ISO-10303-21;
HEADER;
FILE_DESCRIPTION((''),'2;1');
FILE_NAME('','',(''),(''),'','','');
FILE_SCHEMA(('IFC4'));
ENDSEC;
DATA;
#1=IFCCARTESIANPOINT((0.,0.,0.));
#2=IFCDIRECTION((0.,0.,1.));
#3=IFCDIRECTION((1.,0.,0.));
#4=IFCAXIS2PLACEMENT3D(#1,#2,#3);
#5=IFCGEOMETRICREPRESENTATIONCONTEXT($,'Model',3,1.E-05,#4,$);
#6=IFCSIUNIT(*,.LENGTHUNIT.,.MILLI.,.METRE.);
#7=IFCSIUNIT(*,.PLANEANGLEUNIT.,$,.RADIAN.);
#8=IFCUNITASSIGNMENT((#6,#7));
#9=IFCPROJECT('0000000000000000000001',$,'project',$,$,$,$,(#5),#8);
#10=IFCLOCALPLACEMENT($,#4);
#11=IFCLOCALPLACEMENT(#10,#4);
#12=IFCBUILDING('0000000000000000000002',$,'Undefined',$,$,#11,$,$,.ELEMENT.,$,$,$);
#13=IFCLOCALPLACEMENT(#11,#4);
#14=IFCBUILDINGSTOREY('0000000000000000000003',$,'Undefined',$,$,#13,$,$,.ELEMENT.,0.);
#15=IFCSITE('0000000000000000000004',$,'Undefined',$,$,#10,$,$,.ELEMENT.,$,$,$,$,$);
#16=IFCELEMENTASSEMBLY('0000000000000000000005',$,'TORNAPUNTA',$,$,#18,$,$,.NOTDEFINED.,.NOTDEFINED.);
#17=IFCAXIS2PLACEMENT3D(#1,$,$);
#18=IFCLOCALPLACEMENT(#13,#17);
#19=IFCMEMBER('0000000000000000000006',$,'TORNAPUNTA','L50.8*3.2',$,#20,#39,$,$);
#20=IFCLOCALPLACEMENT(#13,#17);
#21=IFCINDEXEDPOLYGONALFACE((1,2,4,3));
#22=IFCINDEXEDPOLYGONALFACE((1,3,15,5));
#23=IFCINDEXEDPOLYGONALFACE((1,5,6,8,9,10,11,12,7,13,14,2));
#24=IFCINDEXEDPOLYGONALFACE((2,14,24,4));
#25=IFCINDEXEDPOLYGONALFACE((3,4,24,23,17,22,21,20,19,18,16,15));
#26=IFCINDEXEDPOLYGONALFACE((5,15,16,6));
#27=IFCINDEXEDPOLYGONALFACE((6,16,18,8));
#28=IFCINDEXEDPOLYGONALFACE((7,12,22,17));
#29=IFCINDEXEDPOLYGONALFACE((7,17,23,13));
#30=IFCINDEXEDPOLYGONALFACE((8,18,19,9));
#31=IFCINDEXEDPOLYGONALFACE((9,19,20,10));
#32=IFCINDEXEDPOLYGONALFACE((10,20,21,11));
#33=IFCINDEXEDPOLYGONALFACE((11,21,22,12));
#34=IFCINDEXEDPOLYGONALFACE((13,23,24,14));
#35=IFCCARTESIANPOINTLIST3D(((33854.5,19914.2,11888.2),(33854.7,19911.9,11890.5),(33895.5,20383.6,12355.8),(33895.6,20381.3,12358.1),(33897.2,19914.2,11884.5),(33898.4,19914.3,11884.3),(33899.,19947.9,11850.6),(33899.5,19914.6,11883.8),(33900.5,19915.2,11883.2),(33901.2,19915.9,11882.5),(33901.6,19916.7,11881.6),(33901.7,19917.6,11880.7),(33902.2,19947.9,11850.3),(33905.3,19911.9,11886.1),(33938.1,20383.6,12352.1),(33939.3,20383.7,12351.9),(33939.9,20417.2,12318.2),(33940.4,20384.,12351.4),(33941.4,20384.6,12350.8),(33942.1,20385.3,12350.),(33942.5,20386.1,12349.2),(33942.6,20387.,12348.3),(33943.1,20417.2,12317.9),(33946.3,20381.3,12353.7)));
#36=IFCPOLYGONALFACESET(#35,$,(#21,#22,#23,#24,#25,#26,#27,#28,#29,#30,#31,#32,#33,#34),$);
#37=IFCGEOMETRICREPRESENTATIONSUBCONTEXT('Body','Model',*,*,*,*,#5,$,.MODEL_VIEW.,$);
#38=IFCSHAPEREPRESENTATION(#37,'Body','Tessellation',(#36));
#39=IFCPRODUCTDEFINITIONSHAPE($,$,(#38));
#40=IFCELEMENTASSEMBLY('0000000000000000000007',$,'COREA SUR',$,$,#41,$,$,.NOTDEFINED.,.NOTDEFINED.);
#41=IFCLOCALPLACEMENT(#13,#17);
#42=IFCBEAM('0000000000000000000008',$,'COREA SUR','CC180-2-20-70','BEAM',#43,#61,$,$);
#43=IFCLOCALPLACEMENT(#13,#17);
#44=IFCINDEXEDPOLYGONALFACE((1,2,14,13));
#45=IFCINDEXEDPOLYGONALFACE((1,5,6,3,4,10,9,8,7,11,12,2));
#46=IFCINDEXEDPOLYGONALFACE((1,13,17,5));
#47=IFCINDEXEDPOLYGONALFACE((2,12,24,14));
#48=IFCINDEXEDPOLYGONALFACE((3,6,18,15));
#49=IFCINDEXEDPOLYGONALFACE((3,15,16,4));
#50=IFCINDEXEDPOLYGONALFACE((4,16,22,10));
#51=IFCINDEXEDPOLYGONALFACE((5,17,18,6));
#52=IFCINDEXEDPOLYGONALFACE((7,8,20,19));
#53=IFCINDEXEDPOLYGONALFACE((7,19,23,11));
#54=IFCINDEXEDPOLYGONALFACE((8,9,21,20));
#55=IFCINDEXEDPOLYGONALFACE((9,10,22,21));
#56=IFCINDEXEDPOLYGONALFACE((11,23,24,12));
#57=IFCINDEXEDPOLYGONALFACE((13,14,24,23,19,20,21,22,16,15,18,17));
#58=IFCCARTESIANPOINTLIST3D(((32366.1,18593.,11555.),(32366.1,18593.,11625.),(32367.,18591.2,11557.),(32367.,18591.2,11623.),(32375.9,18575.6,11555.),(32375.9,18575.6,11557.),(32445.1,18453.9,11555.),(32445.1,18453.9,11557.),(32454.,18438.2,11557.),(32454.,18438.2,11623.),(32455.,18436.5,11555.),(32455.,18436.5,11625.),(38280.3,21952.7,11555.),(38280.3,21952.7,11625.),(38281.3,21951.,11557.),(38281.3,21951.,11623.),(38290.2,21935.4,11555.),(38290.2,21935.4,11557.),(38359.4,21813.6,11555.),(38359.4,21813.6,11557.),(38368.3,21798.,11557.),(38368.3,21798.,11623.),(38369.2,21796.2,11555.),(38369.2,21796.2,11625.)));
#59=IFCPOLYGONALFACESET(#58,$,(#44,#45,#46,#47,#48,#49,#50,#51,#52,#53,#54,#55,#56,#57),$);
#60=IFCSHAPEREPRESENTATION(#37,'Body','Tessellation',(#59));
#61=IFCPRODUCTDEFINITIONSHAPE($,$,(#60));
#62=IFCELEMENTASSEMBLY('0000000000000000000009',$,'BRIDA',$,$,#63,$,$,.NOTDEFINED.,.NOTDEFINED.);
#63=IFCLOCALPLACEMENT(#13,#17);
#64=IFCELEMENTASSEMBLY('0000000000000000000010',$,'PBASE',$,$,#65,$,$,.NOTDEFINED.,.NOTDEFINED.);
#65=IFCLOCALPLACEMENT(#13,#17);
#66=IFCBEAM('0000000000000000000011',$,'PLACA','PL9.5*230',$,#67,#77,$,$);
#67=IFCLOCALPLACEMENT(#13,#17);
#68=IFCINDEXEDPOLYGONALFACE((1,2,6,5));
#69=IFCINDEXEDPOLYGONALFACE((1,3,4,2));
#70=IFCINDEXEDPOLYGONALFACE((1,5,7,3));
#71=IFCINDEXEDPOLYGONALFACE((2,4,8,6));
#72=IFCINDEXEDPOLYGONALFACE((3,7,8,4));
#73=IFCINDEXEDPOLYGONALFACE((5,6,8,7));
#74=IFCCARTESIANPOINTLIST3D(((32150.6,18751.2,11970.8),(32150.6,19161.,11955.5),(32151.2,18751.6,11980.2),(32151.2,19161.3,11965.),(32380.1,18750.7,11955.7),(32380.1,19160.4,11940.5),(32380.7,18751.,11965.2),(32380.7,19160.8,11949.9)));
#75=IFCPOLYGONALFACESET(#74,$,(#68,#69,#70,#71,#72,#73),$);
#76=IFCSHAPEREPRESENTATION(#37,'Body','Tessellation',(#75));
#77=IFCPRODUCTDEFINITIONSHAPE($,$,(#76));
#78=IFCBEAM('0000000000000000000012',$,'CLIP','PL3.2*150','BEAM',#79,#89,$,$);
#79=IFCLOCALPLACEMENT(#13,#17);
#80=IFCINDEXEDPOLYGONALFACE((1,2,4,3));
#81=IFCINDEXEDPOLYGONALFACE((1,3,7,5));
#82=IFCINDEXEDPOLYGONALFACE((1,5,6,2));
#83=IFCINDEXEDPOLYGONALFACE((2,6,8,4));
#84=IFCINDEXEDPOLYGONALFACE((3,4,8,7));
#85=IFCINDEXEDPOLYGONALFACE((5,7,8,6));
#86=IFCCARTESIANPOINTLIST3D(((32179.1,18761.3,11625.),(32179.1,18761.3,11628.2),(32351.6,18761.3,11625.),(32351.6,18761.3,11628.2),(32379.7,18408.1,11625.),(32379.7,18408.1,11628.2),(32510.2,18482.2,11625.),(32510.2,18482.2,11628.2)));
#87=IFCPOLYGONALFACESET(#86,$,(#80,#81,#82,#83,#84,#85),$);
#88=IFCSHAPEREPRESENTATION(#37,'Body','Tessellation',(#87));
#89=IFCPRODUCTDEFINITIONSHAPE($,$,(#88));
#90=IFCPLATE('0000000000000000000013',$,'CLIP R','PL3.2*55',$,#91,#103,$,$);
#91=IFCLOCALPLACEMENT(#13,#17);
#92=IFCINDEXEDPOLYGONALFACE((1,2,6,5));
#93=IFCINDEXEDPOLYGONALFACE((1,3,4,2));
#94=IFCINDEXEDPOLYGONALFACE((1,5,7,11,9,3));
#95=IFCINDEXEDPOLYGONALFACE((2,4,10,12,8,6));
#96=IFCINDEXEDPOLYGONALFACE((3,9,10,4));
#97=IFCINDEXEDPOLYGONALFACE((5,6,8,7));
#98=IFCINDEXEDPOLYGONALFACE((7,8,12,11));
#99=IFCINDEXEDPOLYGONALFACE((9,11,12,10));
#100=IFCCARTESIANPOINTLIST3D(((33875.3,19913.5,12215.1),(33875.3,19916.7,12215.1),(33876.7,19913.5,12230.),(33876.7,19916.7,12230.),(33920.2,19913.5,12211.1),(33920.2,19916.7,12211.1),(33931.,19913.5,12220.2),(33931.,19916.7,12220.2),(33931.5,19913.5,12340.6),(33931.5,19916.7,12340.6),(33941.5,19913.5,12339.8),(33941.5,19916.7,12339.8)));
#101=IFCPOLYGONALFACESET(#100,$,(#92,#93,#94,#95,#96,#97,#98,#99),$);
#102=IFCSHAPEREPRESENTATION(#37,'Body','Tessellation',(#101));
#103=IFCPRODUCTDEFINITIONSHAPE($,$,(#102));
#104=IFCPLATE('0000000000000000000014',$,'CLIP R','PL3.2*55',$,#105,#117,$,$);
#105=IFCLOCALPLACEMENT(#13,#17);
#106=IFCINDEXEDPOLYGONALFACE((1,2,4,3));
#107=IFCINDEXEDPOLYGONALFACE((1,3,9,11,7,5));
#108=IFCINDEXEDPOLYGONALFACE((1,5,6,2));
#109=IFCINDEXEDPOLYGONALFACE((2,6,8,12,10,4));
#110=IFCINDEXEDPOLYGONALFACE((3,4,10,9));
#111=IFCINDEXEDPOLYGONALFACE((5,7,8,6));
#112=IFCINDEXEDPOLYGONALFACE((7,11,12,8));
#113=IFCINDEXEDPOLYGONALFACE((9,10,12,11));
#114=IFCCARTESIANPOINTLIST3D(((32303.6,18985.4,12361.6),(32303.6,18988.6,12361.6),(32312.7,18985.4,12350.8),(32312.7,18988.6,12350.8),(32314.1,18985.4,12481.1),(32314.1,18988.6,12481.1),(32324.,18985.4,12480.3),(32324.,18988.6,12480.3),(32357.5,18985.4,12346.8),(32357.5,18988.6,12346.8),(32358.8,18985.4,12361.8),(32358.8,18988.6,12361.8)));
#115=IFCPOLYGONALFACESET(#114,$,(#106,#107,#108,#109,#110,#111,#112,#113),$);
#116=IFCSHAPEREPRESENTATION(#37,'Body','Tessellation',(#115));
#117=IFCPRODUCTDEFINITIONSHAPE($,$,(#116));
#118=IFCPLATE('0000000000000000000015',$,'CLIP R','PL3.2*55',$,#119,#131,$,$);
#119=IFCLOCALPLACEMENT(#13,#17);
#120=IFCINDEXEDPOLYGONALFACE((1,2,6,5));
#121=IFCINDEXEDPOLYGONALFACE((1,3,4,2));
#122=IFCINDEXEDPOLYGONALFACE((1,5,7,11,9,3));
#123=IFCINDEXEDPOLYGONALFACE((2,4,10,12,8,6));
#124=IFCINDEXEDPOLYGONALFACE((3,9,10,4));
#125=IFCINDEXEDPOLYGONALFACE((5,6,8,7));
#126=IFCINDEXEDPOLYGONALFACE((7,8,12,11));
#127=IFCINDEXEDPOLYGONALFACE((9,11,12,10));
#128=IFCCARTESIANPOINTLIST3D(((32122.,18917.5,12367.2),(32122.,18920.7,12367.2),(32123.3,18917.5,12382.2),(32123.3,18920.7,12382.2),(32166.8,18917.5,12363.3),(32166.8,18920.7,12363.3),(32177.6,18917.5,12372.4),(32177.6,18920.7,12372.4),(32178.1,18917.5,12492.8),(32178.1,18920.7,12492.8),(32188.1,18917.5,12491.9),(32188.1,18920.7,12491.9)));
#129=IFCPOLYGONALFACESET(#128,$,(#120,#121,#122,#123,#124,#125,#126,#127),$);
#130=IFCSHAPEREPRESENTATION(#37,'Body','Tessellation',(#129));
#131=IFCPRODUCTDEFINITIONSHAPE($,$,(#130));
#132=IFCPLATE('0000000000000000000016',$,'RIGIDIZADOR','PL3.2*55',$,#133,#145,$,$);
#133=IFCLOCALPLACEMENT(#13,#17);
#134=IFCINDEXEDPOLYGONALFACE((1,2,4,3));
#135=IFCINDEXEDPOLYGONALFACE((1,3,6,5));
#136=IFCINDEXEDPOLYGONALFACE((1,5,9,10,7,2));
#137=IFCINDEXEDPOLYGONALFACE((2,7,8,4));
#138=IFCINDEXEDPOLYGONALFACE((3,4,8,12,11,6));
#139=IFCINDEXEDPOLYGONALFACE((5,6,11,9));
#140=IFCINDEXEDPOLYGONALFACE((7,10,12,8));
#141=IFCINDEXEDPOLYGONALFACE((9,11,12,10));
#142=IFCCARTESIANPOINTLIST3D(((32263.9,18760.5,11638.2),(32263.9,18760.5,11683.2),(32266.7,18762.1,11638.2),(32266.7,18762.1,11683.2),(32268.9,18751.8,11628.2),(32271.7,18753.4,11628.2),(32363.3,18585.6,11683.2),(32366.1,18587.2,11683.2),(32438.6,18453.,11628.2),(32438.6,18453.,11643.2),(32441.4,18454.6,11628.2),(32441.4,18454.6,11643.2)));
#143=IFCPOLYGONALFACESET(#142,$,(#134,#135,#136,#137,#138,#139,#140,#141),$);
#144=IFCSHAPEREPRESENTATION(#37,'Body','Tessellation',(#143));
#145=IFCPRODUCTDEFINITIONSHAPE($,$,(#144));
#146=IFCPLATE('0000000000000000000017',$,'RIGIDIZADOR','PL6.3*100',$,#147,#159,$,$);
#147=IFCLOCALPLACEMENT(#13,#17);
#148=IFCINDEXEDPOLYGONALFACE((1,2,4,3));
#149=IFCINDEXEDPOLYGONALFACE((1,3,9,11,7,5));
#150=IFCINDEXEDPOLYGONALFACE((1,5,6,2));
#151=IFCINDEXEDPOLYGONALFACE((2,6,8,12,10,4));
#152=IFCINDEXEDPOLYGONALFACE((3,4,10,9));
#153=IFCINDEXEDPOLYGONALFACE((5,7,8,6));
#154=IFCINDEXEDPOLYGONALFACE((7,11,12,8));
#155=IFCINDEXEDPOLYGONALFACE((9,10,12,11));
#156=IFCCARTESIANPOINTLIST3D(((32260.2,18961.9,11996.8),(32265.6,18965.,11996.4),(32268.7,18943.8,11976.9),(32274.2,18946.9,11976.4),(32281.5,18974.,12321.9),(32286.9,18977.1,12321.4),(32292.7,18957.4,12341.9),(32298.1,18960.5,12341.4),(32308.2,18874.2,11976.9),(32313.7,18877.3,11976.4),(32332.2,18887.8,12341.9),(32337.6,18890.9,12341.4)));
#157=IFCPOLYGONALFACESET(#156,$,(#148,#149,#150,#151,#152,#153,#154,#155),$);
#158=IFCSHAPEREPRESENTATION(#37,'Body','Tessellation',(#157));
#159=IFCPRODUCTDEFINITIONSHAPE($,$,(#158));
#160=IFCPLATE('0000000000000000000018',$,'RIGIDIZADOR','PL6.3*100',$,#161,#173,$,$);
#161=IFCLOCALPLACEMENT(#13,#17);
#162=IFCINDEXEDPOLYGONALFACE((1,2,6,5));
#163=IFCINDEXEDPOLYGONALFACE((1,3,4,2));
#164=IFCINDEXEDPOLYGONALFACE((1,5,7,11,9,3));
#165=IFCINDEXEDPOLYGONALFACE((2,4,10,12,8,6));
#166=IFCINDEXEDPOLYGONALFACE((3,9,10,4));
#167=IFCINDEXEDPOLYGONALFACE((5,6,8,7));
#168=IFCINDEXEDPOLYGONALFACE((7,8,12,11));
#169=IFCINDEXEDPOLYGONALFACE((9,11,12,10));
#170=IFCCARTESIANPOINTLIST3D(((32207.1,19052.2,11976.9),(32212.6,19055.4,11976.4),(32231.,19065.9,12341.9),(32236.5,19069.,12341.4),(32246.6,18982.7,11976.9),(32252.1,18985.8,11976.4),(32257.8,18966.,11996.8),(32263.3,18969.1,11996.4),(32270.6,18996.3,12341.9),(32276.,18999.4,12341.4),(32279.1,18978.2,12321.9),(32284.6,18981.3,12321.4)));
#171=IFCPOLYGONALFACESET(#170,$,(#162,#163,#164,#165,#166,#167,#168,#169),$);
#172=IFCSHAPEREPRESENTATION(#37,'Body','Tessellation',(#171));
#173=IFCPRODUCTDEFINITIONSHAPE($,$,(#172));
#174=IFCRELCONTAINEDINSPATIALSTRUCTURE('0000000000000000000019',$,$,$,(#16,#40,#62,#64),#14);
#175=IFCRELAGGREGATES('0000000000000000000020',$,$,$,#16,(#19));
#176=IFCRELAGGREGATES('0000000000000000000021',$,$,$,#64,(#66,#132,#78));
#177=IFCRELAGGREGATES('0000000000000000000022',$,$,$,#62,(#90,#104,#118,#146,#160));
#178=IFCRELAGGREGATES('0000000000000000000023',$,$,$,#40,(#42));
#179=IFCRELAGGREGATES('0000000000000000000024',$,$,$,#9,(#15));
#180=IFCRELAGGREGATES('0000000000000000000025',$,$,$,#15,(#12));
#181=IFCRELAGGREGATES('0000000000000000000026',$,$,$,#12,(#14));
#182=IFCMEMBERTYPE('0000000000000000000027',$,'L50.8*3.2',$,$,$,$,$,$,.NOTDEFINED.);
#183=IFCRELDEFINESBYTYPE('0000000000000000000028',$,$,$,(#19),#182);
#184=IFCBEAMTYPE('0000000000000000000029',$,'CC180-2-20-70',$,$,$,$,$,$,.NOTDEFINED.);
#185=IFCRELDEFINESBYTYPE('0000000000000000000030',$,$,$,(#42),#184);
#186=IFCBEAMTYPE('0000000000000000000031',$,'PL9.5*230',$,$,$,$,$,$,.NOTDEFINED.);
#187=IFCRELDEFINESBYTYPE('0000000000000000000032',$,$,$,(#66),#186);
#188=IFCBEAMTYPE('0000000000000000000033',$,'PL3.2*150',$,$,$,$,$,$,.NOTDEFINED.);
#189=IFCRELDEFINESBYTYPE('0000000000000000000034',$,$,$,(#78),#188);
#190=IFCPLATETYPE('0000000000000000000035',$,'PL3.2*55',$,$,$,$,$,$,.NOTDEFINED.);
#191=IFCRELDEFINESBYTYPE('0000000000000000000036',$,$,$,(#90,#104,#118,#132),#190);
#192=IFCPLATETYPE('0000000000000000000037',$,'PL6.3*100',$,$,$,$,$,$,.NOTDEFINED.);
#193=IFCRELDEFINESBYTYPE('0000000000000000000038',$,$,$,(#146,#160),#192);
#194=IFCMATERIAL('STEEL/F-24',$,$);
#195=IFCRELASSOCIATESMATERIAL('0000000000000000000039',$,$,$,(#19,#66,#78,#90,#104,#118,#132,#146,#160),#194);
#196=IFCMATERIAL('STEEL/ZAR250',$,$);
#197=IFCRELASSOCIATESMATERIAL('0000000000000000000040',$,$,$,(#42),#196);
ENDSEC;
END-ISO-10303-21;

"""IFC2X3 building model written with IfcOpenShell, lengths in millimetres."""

from ifc_helpers import new_model, si_unit, frame, origin_with_axes, origin_2d_with_axis, place, context, subcontext, project, spatial, polyline, rectangle, l_section, c_section, outline, extrude, clip, halfspace, material, type_object, element, aggregate, save


model = new_model("IFC2X3")

# Units and contexts
model_context = context("Model", 3, precision=1e-05, world=origin_with_axes())
body_context = subcontext(model_context, "Body", "Model", "MODEL_VIEW")
ifc_project = project(units=[si_unit("LENGTHUNIT", "METRE", prefix="MILLI"), si_unit("PLANEANGLEUNIT", "RADIAN")], contexts=[model_context])

# Site, building, storey
site_placement = place(None, origin_with_axes())
site = spatial("IfcSite", under=ifc_project, at=site_placement, Name="Undefined", CompositionType="ELEMENT")
building_placement = place(site_placement, origin_with_axes())
building = spatial("IfcBuilding", under=site, at=building_placement, Name="Undefined", CompositionType="ELEMENT")
storey_placement = place(building_placement, origin_with_axes())
storey = spatial("IfcBuildingStorey", under=building, at=storey_placement, Name="Undefined", CompositionType="ELEMENT", Elevation=0.0)

# Element assembly, member
assembly_1_placement = place(storey_placement, origin_with_axes())
assembly_1 = element("IfcElementAssembly", 1, at=assembly_1_placement, inside=storey, Name="TORNAPUNTA", AssemblyPlace="NOTDEFINED", PredefinedType="NOTDEFINED")
ifc_material_1 = material(Name="STEEL/F-24")
member_type_1 = type_object("IfcMemberType", Name="L50.8*3.2", PredefinedType="NOTDEFINED")
member_1_placement = place(assembly_1_placement, frame((33878.5, 19929.9, 11870.4), z_axis=(-0.061634, 0.707107, -0.704416), x_axis=(0.061634, 0.707107, 0.704416)))
member_1 = element("IfcMember", 2, at=member_1_placement, type_object=member_type_1, material=ifc_material_1, Name="TORNAPUNTA", Description="L50.8*3.2", context=body_context, shape_type="SweptSolid", body=[
    extrude(l_section(Depth=50.8, Width=50.8, Thickness=3.2, FilletRadius=4.8, at=origin_2d_with_axis()), frame((663.8, 0.0, 0.0), z_axis=(-1.0, 0.0, 0.0), x_axis=(0.0, -1.0, 0.0)), (0.0, 0.0, 1.0), 663.8),
])
aggregate(assembly_1, [member_1])

# Element assembly, beam
assembly_2_placement = place(storey_placement, origin_with_axes())
assembly_2 = element("IfcElementAssembly", 3, at=assembly_2_placement, inside=storey, Name="COREA SUR", AssemblyPlace="NOTDEFINED", PredefinedType="NOTDEFINED")
ifc_material_2 = material(Name="STEEL/ZAR250")
beam_type_1 = type_object("IfcBeamType", Name="CC180-2-20-70", PredefinedType="NOTDEFINED")
beam_1_placement = place(assembly_2_placement, frame((32410.5, 18514.7, 11590.0), z_axis=(0.493942, -0.869495, 0.0), x_axis=(0.869495, 0.493942, 0.0)))
beam_1 = element("IfcBeam", 4, at=beam_1_placement, type_object=beam_type_1, material=ifc_material_2, Name="COREA SUR", Description="CC180-2-20-70", ObjectType="BEAM", context=body_context, shape_type="SweptSolid", body=[
    extrude(c_section(Depth=180.0, Width=70.0, WallThickness=2.0, Girth=20.0, at=origin_2d_with_axis()), frame((6802.0, 0.0, 0.0), z_axis=(-1.0, 0.0, 0.0), x_axis=(0.0, -1.0, 0.0)), (0.0, 0.0, 1.0), 6802.0),
])

# Element assembly
assembly_3_placement = place(storey_placement, origin_with_axes())
assembly_3 = element("IfcElementAssembly", 5, at=assembly_3_placement, inside=storey, Name="BRIDA", AssemblyPlace="NOTDEFINED", PredefinedType="NOTDEFINED")

# Element assembly, beams
assembly_4_placement = place(storey_placement, origin_with_axes())
assembly_4 = element("IfcElementAssembly", 6, at=assembly_4_placement, inside=storey, Name="PBASE", AssemblyPlace="NOTDEFINED", PredefinedType="NOTDEFINED")
beam_type_2 = type_object("IfcBeamType", Name="PL9.5*230", PredefinedType="NOTDEFINED")
beam_2_placement = place(assembly_4_placement, frame((32265.6, 18751.1, 11968.0), z_axis=(0.997859, -0.002436, -0.065364), x_axis=(0.0, 0.999306, -0.037243)))
beam_2 = element("IfcBeam", 7, at=beam_2_placement, type_object=beam_type_2, material=ifc_material_1, Name="PLACA", Description="PL9.5*230", context=body_context, shape_type="SweptSolid", body=[
    extrude(rectangle(XDim=9.5, YDim=230.0, at=origin_2d_with_axis()), frame((410.0, 0.0, 0.0), z_axis=(-1.0, 0.0, 0.0), x_axis=(0.0, -1.0, 0.0)), (0.0, 0.0, 1.0), 410.0),
])
beam_type_3 = type_object("IfcBeamType", Name="PL3.2*150", PredefinedType="NOTDEFINED")
beam_3_placement = place(assembly_4_placement, frame((32265.3, 18761.3, 11626.6), z_axis=(0.869505, 0.493924, 0.0), x_axis=(0.493924, -0.869505, 0.0)))
beam_3 = element("IfcBeam", 8, at=beam_3_placement, type_object=beam_type_3, material=ifc_material_1, Name="CLIP", Description="PL3.2*150", ObjectType="BEAM", context=body_context, shape_type="Clipping", body=[
    clip(extrude(rectangle(XDim=3.2, YDim=150.0, at=origin_2d_with_axis()), frame((363.7, 0.0, 0.0), z_axis=(-1.0, 0.0, 0.0), x_axis=(0.0, -1.0, 0.0)), (0.0, 0.0, 1.0), 471.8), halfspace(frame((0.0, 0.0, 0.0), z_axis=(0.869505, 0.0, -0.493924), x_axis=(-0.493924, 0.0, -0.869505)), True)),
])

# Plates
plate_type_1 = type_object("IfcPlateType", Name="PL3.2*55", PredefinedType="NOTDEFINED")
plate_1_placement = place(assembly_3_placement, frame((33941.5, 19915.1, 12339.8), z_axis=(0.0, -1.0, 0.0), x_axis=(-0.996194, 0.0, 0.087163)))
plate_1 = element("IfcPlate", 9, at=plate_1_placement, type_object=plate_type_1, material=ifc_material_1, Name="CLIP R", Description="PL3.2*55", context=body_context, shape_type="SweptSolid", body=[
    extrude(outline(polyline([(0.0, 0.0), (10.0, 0.0), (55.0, 115.0), (55.0, 130.0), (10.0, 130.0), (0.0, 120.0), (0.0, 0.0)])), frame((0.0, 0.0, -1.6), z_axis=(0.0, 0.0, 1.0), x_axis=(1.0, 0.0, 0.0)), (0.0, 0.0, 1.0), 3.2),
])
plate_2_placement = place(assembly_3_placement, frame((32314.1, 18987.0, 12481.1), z_axis=(0.0, 1.0, 0.0), x_axis=(0.996195, 0.0, -0.087155)))
plate_2 = element("IfcPlate", 10, at=plate_2_placement, type_object=plate_type_1, material=ifc_material_1, Name="CLIP R", Description="PL3.2*55", context=body_context, shape_type="SweptSolid", body=[
    extrude(outline(polyline([(0.0, 0.0), (10.0, 0.0), (55.0, 115.0), (55.0, 130.0), (10.0, 130.0), (0.0, 120.0), (0.0, 0.0)])), frame((0.0, 0.0, -1.6), z_axis=(0.0, 0.0, 1.0), x_axis=(1.0, 0.0, 0.0)), (0.0, 0.0, 1.0), 3.2),
])
plate_3_placement = place(assembly_3_placement, frame((32188.1, 18919.1, 12491.9), z_axis=(0.0, -1.0, 0.0), x_axis=(-0.996194, 0.0, 0.087163)))
plate_3 = element("IfcPlate", 11, at=plate_3_placement, type_object=plate_type_1, material=ifc_material_1, Name="CLIP R", Description="PL3.2*55", context=body_context, shape_type="SweptSolid", body=[
    extrude(outline(polyline([(0.0, 0.0), (10.0, 0.0), (55.0, 115.0), (55.0, 130.0), (10.0, 130.0), (0.0, 120.0), (0.0, 0.0)])), frame((0.0, 0.0, -1.6), z_axis=(0.0, 0.0, 1.0), x_axis=(1.0, 0.0, 0.0)), (0.0, 0.0, 1.0), 3.2),
])
plate_4_placement = place(assembly_4_placement, frame((32364.7, 18586.4, 11683.2), z_axis=(0.869505, 0.493924, 0.0), x_axis=(0.477762, -0.841054, -0.253717)))
plate_4 = element("IfcPlate", 12, at=plate_4_placement, type_object=plate_type_1, material=ifc_material_1, Name="RIGIDIZADOR", Description="PL3.2*55", context=body_context, shape_type="SweptSolid", body=[
    extrude(outline(polyline([(0.0, 0.0), (157.7, 0.0), (161.5, 14.5), (-171.0, 101.7), (-183.2, 94.6), (-194.6, 51.0), (0.0, 0.0)])), frame((0.0, 0.0, -1.6), z_axis=(0.0, 0.0, 1.0), x_axis=(1.0, 0.0, 0.0)), (0.0, 0.0, 1.0), 3.2),
])
aggregate(assembly_4, [beam_2, plate_4, beam_3])
plate_type_2 = type_object("IfcPlateType", Name="PL6.3*100", PredefinedType="NOTDEFINED")
plate_5_placement = place(assembly_3_placement, frame((32311.0, 18875.8, 11976.7), z_axis=(0.86703, 0.492542, -0.075245), x_axis=(-0.493942, 0.869495, 0.000005)))
plate_5 = element("IfcPlate", 13, at=plate_5_placement, type_object=plate_type_2, material=ifc_material_1, Name="RIGIDIZADOR", Description="PL6.3*100", context=body_context, shape_type="SweptSolid", body=[
    extrude(outline(polyline([(0.0, 0.0), (80.0, 0.0), (100.0, 20.0), (100.0, 346.0), (80.0, 366.0), (0.0, 366.0), (0.0, 0.0)])), frame((0.0, 0.0, -3.1), z_axis=(0.0, 0.0, 1.0), x_axis=(1.0, 0.0, 0.0)), (0.0, 0.0, 1.0), 6.3),
])
plate_6_placement = place(assembly_3_placement, frame((32259.2, 18966.9, 11976.7), z_axis=(0.86703, 0.492542, -0.075245), x_axis=(-0.493942, 0.869495, 0.000005)))
plate_6 = element("IfcPlate", 14, at=plate_6_placement, type_object=plate_type_2, material=ifc_material_1, Name="RIGIDIZADOR", Description="PL6.3*100", context=body_context, shape_type="SweptSolid", body=[
    extrude(outline(polyline([(0.0, 20.0), (20.0, 0.0), (100.0, 0.0), (100.0, 366.0), (20.0, 366.0), (0.0, 346.0), (0.0, 20.0)])), frame((0.0, 0.0, -3.1), z_axis=(0.0, 0.0, 1.0), x_axis=(1.0, 0.0, 0.0)), (0.0, 0.0, 1.0), 6.3),
])

aggregate(assembly_3, [plate_1, plate_2, plate_3, plate_5, plate_6])

aggregate(assembly_2, [beam_1])

save(model, "model.ifc")
